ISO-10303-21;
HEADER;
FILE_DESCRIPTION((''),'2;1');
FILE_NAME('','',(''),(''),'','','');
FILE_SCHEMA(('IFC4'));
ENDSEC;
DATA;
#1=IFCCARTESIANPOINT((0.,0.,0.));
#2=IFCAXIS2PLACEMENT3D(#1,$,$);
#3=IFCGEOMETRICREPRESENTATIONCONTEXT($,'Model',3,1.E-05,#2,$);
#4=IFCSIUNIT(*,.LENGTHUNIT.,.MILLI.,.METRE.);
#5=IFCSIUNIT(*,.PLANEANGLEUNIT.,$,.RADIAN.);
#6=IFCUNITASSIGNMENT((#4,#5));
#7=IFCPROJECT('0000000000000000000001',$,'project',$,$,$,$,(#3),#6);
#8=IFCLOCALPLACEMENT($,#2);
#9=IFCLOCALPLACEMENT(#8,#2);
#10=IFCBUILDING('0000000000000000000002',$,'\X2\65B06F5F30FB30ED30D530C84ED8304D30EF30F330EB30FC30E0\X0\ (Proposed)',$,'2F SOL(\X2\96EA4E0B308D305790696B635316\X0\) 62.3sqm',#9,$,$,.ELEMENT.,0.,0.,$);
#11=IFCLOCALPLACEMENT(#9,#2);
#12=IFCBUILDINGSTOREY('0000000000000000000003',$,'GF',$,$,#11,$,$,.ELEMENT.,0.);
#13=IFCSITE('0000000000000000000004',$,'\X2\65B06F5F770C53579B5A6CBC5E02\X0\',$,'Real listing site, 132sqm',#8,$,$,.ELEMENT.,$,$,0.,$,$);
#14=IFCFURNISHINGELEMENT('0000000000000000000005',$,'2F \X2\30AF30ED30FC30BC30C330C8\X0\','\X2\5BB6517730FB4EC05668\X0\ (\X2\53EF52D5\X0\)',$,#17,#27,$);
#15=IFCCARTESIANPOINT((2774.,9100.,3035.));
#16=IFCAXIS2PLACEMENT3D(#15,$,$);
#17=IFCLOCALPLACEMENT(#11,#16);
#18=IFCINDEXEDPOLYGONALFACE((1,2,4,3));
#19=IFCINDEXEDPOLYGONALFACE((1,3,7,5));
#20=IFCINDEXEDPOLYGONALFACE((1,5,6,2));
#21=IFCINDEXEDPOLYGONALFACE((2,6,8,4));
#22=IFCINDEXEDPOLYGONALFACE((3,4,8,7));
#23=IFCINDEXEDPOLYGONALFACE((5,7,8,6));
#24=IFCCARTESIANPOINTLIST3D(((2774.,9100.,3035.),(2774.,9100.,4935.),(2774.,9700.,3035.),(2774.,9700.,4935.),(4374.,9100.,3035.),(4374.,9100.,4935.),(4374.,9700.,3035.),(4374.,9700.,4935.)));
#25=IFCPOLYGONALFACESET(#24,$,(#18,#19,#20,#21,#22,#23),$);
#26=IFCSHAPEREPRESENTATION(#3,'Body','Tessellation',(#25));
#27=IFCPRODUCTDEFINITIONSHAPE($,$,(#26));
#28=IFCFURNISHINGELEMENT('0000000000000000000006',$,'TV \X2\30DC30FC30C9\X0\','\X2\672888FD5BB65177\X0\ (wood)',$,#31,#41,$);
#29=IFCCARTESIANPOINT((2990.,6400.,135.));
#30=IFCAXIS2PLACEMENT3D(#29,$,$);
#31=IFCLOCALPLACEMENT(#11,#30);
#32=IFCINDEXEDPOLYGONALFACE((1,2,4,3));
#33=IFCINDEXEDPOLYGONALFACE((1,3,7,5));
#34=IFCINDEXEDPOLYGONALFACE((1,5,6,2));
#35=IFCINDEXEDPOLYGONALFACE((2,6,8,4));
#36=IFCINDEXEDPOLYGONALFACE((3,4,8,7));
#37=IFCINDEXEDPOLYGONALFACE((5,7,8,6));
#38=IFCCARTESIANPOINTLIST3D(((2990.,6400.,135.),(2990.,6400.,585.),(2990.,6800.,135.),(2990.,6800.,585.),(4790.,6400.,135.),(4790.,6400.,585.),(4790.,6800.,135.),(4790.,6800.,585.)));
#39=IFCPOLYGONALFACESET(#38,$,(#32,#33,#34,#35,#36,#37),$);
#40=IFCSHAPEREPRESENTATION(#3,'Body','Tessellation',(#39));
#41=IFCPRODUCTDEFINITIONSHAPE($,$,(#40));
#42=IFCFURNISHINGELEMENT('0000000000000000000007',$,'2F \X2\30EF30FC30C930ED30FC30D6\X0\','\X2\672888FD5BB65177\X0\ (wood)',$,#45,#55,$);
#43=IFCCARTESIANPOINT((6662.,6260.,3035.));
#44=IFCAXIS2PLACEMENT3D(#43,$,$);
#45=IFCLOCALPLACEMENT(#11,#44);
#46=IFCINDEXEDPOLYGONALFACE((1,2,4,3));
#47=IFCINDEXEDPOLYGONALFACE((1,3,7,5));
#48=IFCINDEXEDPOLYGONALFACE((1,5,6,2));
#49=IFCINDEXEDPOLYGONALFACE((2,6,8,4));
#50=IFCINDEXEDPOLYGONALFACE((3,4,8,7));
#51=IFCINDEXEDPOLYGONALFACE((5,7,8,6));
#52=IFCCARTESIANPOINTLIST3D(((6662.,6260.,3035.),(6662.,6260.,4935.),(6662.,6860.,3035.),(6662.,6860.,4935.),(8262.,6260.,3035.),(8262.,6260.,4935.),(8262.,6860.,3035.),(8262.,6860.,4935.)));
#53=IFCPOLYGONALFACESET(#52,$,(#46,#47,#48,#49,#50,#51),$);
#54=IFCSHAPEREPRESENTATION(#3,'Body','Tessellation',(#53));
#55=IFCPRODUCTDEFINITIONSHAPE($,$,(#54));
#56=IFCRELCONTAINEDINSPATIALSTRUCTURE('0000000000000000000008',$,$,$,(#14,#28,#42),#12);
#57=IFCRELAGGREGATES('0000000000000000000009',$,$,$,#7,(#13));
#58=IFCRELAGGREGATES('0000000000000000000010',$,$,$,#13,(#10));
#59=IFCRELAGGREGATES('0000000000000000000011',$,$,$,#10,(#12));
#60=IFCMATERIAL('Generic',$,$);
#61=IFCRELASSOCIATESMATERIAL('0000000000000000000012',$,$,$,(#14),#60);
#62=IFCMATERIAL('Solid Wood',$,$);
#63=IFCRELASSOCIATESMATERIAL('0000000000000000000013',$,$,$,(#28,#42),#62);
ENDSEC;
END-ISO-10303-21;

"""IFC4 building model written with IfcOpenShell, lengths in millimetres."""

from ifc_helpers import new_model, si_unit, frame, frame_2d, origin, place, context, project, spatial, rectangle, extrude, material, element, save


model = new_model("IFC4")

# Units and contexts
model_context = context("Model", 3, precision=1e-05, world=origin())
ifc_project = project(units=[si_unit("LENGTHUNIT", "METRE", prefix="MILLI"), si_unit("PLANEANGLEUNIT", "RADIAN")], contexts=[model_context])

# Site, building, storey
site_placement = place(None, origin())
site = spatial("IfcSite", under=ifc_project, at=site_placement, Name="新潟県南魚沼市", ObjectType="Real listing site, 132sqm", CompositionType="ELEMENT", RefElevation=0.0)
building_placement = place(site_placement, origin())
building = spatial("IfcBuilding", under=site, at=building_placement, Name="新潟・ロフト付きワンルーム (Proposed)", ObjectType="2F SOL(雪下ろし適正化) 62.3sqm", CompositionType="ELEMENT", ElevationOfRefHeight=0.0, ElevationOfTerrain=0.0)
storey_placement = place(building_placement, origin())
storey = spatial("IfcBuildingStorey", under=building, at=storey_placement, Name="GF", CompositionType="ELEMENT", Elevation=0.0)

# Shared definitions
ifc_material_1 = material(Name="Solid Wood")

# Shared definitions
ifc_material_2 = material(Name="Generic")

# Furnishing elements
furnishing_1_placement = place(storey_placement, frame((2774.0, 9100.0, 3035.0)))
element("IfcFurnishingElement", 1, at=furnishing_1_placement, inside=storey, material=ifc_material_2, Name="2F クローゼット", Description="家具・什器 (可動)", context=model_context, shape_type="SweptSolid", body=[
    extrude(rectangle(XDim=1600.0, YDim=600.0, at=frame_2d((800.0, 300.0))), frame((2774.0, 9100.0, 3035.0)), (0.0, 0.0, 1.0), 1900.0),
])
furnishing_2_placement = place(storey_placement, frame((2990.0, 6400.0, 135.0)))
element("IfcFurnishingElement", 2, at=furnishing_2_placement, inside=storey, material=ifc_material_1, Name="TV ボード", Description="木製家具 (wood)", context=model_context, shape_type="SweptSolid", body=[
    extrude(rectangle(XDim=1800.0, YDim=400.0, at=frame_2d((900.0, 200.0))), frame((2990.0, 6400.0, 135.0)), (0.0, 0.0, 1.0), 450.0),
])
furnishing_3_placement = place(storey_placement, frame((6662.0, 6260.0, 3035.0)))
element("IfcFurnishingElement", 3, at=furnishing_3_placement, inside=storey, material=ifc_material_1, Name="2F ワードローブ", Description="木製家具 (wood)", context=model_context, shape_type="SweptSolid", body=[
    extrude(rectangle(XDim=1600.0, YDim=600.0, at=frame_2d((800.0, 300.0))), frame((6662.0, 6260.0, 3035.0)), (0.0, 0.0, 1.0), 1900.0),
])

save(model, "model.ifc")
